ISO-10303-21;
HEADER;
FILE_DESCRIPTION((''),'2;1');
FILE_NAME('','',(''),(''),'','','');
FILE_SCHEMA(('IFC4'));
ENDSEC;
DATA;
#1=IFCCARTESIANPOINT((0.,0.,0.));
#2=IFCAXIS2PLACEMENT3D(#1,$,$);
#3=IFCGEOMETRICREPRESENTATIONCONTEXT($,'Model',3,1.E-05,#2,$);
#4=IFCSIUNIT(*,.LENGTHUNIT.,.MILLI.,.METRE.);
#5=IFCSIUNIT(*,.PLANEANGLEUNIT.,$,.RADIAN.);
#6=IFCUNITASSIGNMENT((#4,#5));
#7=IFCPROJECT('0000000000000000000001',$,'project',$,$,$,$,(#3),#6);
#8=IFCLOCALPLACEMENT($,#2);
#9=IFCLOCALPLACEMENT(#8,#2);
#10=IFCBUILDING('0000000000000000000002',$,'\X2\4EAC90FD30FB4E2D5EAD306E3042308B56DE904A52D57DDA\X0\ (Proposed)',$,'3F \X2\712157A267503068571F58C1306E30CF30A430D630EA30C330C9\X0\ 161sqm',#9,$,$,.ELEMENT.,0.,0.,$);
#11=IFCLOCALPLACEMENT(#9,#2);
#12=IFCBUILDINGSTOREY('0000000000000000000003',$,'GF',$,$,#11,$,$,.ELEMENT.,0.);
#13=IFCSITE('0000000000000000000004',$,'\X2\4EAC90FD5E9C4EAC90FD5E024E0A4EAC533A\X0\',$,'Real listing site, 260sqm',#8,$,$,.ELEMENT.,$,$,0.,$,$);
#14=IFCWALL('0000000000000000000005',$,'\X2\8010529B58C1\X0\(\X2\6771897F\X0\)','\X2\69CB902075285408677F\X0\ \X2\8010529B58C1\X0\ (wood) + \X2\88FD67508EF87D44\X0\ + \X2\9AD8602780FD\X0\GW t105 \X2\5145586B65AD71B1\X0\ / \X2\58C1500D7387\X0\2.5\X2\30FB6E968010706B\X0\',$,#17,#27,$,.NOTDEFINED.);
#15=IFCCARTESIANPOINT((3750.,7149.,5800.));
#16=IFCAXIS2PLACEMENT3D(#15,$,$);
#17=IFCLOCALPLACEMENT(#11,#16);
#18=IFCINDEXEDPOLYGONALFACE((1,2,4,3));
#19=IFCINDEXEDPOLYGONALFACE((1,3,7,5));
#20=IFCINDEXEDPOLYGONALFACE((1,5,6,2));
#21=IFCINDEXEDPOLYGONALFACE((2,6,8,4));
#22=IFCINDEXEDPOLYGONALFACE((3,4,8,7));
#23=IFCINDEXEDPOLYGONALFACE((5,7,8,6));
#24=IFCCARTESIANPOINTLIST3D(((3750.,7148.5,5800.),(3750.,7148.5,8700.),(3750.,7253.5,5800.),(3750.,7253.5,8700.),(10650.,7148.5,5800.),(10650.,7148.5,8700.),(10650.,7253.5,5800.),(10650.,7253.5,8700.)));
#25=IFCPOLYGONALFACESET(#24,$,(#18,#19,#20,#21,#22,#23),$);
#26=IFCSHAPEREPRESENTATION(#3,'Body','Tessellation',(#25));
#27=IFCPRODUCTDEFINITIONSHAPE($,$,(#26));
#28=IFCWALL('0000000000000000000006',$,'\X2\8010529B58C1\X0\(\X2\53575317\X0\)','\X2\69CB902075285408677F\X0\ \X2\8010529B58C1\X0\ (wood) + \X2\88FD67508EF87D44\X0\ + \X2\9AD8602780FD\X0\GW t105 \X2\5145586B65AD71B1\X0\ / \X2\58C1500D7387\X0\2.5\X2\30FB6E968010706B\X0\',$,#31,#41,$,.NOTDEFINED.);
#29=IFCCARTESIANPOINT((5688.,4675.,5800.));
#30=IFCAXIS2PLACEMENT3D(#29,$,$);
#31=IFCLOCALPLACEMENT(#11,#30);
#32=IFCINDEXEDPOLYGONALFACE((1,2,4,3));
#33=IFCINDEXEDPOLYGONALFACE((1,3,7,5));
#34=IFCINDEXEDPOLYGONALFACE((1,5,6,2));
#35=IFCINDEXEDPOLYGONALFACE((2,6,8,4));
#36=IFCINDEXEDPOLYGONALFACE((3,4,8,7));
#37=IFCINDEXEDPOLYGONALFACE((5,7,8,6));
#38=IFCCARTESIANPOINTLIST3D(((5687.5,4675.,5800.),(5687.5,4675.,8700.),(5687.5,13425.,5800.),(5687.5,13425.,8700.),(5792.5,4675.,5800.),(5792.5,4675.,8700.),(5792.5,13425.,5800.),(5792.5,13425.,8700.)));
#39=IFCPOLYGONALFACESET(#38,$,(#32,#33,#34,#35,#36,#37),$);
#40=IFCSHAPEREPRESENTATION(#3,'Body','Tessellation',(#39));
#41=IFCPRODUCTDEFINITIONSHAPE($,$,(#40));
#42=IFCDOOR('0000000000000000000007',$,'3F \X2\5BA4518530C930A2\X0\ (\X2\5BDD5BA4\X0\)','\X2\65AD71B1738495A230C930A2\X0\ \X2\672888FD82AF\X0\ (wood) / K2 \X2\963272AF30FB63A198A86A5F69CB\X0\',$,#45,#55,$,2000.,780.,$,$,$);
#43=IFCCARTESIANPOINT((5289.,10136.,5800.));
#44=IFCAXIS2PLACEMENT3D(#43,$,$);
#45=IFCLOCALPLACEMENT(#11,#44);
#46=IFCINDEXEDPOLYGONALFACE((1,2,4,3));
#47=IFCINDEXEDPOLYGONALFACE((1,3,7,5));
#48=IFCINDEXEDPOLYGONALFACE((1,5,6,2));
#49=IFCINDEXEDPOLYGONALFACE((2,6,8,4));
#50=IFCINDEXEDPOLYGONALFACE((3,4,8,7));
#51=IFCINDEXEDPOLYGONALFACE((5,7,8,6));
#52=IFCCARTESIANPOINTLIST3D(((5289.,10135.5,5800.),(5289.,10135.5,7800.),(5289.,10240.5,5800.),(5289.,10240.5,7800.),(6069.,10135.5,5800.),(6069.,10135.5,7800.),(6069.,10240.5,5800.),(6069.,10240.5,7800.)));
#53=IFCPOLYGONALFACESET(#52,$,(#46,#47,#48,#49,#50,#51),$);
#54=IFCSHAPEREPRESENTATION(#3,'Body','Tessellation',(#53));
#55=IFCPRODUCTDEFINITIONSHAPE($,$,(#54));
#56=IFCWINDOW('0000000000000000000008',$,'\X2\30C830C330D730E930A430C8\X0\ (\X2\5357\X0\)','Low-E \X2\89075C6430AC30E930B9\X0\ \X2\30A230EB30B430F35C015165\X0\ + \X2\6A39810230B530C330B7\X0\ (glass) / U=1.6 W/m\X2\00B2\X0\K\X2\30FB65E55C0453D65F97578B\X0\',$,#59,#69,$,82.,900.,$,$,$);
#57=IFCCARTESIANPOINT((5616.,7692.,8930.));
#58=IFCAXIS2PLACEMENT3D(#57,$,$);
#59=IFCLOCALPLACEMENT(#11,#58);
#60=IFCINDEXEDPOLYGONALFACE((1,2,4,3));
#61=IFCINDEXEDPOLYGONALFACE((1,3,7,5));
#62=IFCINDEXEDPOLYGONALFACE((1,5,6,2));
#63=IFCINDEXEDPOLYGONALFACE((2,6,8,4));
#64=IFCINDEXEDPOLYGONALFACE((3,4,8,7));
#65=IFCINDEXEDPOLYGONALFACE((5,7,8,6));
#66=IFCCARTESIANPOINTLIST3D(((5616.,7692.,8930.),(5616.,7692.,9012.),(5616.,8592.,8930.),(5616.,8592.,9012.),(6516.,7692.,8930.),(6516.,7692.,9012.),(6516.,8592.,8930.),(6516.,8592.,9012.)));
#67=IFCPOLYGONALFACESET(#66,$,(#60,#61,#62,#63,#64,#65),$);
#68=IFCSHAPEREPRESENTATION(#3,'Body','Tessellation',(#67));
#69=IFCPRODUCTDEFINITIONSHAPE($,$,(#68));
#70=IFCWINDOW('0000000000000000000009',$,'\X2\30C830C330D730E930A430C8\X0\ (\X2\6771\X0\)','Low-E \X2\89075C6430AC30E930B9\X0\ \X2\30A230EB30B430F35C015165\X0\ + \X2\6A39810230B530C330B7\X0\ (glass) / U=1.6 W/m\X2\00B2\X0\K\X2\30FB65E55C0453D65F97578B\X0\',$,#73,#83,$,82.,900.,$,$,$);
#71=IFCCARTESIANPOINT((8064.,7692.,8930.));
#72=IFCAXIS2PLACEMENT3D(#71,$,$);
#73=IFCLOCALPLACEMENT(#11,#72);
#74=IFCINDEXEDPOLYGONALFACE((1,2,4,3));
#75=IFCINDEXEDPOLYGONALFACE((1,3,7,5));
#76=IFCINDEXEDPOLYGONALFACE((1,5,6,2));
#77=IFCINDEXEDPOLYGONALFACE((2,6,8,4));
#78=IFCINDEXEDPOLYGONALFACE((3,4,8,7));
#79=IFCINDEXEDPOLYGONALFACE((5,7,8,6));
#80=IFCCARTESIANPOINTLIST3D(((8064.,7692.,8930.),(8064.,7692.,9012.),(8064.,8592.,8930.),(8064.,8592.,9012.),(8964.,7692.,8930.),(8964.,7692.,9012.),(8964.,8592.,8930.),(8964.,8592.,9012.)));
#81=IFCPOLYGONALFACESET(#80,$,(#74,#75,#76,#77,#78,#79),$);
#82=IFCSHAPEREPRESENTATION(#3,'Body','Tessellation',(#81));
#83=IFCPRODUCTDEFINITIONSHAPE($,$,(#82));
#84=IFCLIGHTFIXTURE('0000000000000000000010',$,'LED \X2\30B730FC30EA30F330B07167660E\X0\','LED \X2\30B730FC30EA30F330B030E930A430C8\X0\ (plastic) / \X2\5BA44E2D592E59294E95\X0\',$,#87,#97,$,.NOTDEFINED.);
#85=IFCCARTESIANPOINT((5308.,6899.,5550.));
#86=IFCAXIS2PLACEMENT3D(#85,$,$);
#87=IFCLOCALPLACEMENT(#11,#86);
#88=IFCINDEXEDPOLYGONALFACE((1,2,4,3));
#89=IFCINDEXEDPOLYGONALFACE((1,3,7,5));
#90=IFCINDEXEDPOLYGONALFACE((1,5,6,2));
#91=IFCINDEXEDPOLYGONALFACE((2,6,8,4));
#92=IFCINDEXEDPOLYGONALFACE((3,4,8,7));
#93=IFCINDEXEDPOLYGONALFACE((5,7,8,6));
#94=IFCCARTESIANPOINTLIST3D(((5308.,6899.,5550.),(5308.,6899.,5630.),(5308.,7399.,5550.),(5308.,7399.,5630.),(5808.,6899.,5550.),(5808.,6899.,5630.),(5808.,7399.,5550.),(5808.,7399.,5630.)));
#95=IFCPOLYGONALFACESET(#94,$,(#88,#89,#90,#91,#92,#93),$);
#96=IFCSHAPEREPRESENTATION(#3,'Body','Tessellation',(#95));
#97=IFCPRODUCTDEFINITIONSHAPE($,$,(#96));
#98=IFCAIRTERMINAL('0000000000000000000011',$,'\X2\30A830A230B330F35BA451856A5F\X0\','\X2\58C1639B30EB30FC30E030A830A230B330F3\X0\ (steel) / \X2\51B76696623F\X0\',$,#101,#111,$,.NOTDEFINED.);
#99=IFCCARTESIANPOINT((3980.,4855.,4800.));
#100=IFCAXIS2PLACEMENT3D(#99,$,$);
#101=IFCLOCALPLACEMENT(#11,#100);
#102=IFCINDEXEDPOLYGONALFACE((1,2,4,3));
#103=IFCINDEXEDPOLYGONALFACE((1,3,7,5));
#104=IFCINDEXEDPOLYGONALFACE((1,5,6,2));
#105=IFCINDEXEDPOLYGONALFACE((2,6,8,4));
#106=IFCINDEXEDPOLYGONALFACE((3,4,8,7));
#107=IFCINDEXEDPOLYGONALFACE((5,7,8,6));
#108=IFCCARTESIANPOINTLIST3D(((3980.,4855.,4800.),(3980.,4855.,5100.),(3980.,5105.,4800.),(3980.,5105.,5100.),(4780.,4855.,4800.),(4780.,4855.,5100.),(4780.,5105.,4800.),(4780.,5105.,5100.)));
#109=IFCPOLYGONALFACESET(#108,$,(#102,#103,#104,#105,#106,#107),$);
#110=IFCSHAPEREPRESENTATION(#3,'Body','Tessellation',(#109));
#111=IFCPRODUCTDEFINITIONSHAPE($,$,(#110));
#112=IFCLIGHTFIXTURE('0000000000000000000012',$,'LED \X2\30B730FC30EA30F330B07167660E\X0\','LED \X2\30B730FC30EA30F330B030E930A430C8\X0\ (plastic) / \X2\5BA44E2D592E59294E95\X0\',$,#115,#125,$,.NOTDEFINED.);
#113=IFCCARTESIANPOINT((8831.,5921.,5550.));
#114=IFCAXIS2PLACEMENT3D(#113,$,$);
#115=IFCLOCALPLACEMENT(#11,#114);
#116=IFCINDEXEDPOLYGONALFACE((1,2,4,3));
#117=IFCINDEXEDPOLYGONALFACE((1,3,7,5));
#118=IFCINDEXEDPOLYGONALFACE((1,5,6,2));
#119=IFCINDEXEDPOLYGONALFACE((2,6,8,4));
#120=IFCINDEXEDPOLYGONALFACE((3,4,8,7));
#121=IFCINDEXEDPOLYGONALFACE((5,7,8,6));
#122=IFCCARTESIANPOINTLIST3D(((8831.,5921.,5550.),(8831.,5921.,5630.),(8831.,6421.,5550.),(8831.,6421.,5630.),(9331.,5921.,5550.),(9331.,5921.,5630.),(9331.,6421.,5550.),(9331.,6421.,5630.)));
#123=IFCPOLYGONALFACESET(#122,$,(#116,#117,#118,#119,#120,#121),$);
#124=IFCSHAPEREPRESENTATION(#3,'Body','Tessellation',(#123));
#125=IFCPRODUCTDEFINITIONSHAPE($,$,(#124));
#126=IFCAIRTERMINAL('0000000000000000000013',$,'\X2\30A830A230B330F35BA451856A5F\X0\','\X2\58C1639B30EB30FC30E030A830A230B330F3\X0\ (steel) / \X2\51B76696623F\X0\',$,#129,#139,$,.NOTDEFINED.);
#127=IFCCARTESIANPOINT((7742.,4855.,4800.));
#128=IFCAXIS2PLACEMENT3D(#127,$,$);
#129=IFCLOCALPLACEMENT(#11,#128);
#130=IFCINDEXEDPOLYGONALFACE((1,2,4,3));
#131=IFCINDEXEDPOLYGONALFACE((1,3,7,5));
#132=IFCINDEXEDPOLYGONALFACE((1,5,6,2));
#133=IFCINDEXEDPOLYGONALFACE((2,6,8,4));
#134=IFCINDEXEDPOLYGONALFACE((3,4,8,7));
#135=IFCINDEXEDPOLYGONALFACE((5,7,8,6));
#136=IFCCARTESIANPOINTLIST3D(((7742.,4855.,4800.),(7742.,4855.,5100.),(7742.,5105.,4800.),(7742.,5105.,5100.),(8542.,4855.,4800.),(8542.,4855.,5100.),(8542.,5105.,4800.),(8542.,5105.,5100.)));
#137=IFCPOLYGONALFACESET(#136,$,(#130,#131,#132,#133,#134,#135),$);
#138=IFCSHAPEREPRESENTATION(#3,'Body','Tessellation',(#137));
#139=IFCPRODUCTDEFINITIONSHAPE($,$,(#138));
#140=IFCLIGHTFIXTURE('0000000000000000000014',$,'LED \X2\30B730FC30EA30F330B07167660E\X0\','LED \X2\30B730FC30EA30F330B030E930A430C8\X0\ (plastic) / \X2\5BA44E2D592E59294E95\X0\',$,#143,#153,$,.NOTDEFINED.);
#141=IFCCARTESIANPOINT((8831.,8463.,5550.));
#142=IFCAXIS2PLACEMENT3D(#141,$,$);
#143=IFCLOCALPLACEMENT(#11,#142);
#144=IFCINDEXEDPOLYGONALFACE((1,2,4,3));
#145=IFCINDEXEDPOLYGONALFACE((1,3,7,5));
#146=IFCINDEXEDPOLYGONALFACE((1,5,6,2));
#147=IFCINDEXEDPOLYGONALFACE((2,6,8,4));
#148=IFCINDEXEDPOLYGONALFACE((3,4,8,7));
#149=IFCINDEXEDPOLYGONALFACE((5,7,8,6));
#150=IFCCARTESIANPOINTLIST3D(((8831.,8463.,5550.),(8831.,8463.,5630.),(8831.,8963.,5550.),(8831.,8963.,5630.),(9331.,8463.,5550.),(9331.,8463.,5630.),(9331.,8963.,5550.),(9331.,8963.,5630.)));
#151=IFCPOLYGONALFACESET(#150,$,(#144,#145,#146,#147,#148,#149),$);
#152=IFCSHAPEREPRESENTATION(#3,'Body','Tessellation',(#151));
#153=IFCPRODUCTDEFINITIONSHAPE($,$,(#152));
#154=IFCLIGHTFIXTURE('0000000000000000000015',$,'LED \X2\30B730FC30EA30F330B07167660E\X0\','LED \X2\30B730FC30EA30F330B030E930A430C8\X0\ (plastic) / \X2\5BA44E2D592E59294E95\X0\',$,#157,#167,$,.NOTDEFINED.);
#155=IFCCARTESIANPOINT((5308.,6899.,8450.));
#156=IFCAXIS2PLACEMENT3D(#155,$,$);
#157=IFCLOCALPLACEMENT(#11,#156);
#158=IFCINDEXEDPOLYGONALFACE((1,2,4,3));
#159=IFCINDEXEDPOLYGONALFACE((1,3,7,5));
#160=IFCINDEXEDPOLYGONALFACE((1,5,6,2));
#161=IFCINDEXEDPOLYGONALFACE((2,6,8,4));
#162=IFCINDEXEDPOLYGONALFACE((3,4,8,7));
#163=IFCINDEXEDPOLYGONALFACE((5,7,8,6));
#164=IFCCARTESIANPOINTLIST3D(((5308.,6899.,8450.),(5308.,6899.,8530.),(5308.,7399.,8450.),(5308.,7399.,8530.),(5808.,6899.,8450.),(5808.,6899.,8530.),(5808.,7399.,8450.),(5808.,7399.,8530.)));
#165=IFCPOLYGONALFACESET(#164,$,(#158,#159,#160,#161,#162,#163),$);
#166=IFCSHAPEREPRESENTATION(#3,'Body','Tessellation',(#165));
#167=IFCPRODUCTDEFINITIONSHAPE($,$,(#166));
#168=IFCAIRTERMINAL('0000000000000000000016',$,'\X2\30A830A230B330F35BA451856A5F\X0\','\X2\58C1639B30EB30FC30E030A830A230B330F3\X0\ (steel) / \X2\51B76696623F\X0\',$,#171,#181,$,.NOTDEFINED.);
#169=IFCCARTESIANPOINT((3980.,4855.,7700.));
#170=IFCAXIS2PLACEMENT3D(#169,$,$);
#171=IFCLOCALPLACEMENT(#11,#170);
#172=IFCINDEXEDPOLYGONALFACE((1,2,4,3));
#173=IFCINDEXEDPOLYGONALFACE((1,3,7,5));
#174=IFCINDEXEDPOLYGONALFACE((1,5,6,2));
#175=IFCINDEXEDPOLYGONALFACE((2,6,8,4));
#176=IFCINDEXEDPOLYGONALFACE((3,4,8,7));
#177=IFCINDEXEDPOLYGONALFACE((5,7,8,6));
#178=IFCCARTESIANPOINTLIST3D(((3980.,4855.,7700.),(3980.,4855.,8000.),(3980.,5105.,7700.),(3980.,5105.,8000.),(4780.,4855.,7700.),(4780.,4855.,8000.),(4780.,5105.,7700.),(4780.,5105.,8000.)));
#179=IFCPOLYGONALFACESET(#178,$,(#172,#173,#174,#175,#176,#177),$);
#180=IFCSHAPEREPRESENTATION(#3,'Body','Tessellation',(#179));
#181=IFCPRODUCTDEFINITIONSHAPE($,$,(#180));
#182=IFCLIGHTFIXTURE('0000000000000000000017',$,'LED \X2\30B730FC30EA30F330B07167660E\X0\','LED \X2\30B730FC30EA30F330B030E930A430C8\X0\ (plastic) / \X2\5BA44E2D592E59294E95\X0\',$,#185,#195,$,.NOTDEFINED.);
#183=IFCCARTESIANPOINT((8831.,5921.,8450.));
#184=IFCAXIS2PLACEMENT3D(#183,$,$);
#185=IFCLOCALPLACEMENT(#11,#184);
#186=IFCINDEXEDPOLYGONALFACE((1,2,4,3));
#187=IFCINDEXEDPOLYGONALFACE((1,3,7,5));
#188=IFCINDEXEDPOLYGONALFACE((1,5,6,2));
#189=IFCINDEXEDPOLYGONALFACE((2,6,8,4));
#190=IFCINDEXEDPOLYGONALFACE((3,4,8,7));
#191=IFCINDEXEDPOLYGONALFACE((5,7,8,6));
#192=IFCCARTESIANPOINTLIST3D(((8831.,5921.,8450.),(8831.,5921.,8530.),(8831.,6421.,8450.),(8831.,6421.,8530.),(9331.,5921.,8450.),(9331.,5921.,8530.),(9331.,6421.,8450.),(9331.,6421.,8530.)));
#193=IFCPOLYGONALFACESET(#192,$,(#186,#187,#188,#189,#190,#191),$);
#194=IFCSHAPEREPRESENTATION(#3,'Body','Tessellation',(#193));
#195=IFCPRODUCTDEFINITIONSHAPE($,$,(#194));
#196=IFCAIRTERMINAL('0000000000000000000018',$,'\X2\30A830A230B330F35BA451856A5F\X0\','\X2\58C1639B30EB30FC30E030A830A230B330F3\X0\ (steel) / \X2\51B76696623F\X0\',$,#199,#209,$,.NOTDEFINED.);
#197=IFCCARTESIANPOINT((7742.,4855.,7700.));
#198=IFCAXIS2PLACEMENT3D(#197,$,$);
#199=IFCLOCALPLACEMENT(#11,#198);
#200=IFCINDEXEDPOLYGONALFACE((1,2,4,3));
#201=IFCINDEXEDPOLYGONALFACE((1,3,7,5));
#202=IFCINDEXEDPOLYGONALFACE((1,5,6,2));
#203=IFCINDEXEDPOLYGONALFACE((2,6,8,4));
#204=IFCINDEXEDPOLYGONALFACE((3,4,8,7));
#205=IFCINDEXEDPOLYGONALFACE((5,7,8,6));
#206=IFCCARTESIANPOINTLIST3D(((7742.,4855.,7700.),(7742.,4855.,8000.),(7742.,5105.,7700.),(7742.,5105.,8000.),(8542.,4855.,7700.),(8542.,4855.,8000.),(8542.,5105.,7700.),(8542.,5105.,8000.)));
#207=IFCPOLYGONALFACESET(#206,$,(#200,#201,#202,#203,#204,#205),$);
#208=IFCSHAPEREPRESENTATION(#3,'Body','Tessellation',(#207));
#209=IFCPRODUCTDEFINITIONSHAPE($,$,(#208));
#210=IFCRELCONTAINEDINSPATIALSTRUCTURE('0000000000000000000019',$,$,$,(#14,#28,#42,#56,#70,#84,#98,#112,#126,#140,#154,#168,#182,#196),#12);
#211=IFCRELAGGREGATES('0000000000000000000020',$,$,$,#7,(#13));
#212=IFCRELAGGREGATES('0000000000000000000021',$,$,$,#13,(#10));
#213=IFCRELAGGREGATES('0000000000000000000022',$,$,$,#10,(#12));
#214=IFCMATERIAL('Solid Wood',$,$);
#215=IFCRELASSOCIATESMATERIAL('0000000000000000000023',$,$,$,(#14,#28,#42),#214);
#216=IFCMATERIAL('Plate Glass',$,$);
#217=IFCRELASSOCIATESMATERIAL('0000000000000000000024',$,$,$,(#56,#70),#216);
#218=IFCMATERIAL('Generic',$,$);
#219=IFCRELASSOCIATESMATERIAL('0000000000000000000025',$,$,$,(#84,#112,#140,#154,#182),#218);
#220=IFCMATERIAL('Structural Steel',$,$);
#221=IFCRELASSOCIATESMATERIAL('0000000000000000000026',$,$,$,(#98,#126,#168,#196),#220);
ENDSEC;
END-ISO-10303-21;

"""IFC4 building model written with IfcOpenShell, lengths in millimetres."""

from ifc_helpers import new_model, si_unit, frame, frame_2d, origin, place, context, project, spatial, rectangle, extrude, material, element, fill, save


model = new_model("IFC4")

# Units and contexts
model_context = context("Model", 3, precision=1e-05, world=origin())
ifc_project = project(units=[si_unit("LENGTHUNIT", "METRE", prefix="MILLI"), si_unit("PLANEANGLEUNIT", "RADIAN")], contexts=[model_context])

# Site, building, storey
site_placement = place(None, origin())
site = spatial("IfcSite", under=ifc_project, at=site_placement, Name="京都府京都市上京区", ObjectType="Real listing site, 260sqm", CompositionType="ELEMENT", RefElevation=0.0)
building_placement = place(site_placement, origin())
building = spatial("IfcBuilding", under=site, at=building_placement, Name="京都・中庭のある回遊動線 (Proposed)", ObjectType="3F 無垢材と土壁のハイブリッド 161sqm", CompositionType="ELEMENT", ElevationOfRefHeight=0.0, ElevationOfTerrain=0.0)
storey_placement = place(building_placement, origin())
storey = spatial("IfcBuildingStorey", under=building, at=storey_placement, Name="GF", CompositionType="ELEMENT", Elevation=0.0)

# Shared definitions
ifc_material_1 = material(Name="Solid Wood")

# Wall
wall_1_placement = place(storey_placement, frame((3750.0, 7149.0, 5800.0)))
element("IfcWall", 1, at=wall_1_placement, inside=storey, material=ifc_material_1, Name="耐力壁(東西)", Description="構造用合板 耐力壁 (wood) + 製材軸組 + 高性能GW t105 充填断熱 / 壁倍率2.5・準耐火", PredefinedType="NOTDEFINED", context=model_context, shape_type="SweptSolid", body=[
    extrude(rectangle(XDim=6900.0, YDim=105.0, at=frame_2d((3450.0, 52.0))), frame((3750.0, 7149.0, 5800.0)), (0.0, 0.0, 1.0), 2900.0),
])

# Wall, opening, door
wall_2_placement = place(storey_placement, frame((5688.0, 4675.0, 5800.0)))
wall_2 = element("IfcWall", 2, at=wall_2_placement, inside=storey, material=ifc_material_1, Name="耐力壁(南北)", Description="構造用合板 耐力壁 (wood) + 製材軸組 + 高性能GW t105 充填断熱 / 壁倍率2.5・準耐火", PredefinedType="NOTDEFINED", context=model_context, shape_type="SweptSolid", body=[
    extrude(rectangle(XDim=105.0, YDim=8750.0, at=frame_2d((52.0, 4375.0))), frame((5688.0, 4675.0, 5800.0)), (0.0, 0.0, 1.0), 2900.0),
])
opening_placement = place(storey_placement, frame((5289.0, 10136.0, 5800.0)))
opening = element("IfcOpeningElement", 3, at=opening_placement, cuts=wall_2, PredefinedType="NOTDEFINED", context=model_context, shape_type="SweptSolid", body=[
    extrude(rectangle(XDim=780.0, YDim=105.0, at=frame_2d((390.0, 52.0))), frame((5289.0, 10136.0, 5800.0)), (0.0, 0.0, 1.0), 2000.0),
])
door_placement = place(storey_placement, frame((5289.0, 10136.0, 5800.0)))
door = element("IfcDoor", 4, at=door_placement, inside=storey, material=ifc_material_1, Name="3F 室内ドア (寝室)", Description="断熱玄関ドア 木製芯 (wood) / K2 防犯・採風機構", OverallHeight=2000.0, OverallWidth=780.0, context=model_context, shape_type="SweptSolid", body=[
    extrude(rectangle(XDim=780.0, YDim=105.0, at=frame_2d((390.0, 52.0))), frame((5289.0, 10136.0, 5800.0)), (0.0, 0.0, 1.0), 2000.0),
])
fill(opening, door)

# Windows
ifc_material_2 = material(Name="Plate Glass")
window_1_placement = place(storey_placement, frame((5616.0, 7692.0, 8930.0)))
element("IfcWindow", 5, at=window_1_placement, inside=storey, material=ifc_material_2, Name="トップライト (南)", Description="Low-E 複層ガラス アルゴン封入 + 樹脂サッシ (glass) / U=1.6 W/m²K・日射取得型", OverallHeight=82.0, OverallWidth=900.0, context=model_context, shape_type="SweptSolid", body=[
    extrude(rectangle(XDim=900.0, YDim=900.0, at=frame_2d((450.0, 450.0))), frame((5616.0, 7692.0, 8930.0)), (0.0, 0.0, 1.0), 82.0),
])
window_2_placement = place(storey_placement, frame((8064.0, 7692.0, 8930.0)))
element("IfcWindow", 6, at=window_2_placement, inside=storey, material=ifc_material_2, Name="トップライト (東)", Description="Low-E 複層ガラス アルゴン封入 + 樹脂サッシ (glass) / U=1.6 W/m²K・日射取得型", OverallHeight=82.0, OverallWidth=900.0, context=model_context, shape_type="SweptSolid", body=[
    extrude(rectangle(XDim=900.0, YDim=900.0, at=frame_2d((450.0, 450.0))), frame((8064.0, 7692.0, 8930.0)), (0.0, 0.0, 1.0), 82.0),
])

# Light fixture
ifc_material_3 = material(Name="Generic")
light_fixture_1_placement = place(storey_placement, frame((5308.0, 6899.0, 5550.0)))
element("IfcLightFixture", 7, at=light_fixture_1_placement, inside=storey, material=ifc_material_3, Name="LED シーリング照明", Description="LED シーリングライト (plastic) / 室中央天井", PredefinedType="NOTDEFINED", context=model_context, shape_type="SweptSolid", body=[
    extrude(rectangle(XDim=500.0, YDim=500.0, at=frame_2d((250.0, 250.0))), frame((5308.0, 6899.0, 5550.0)), (0.0, 0.0, 1.0), 80.0),
])

# Air terminal
ifc_material_4 = material(Name="Structural Steel")
air_terminal_1_placement = place(storey_placement, frame((3980.0, 4855.0, 4800.0)))
element("IfcAirTerminal", 8, at=air_terminal_1_placement, inside=storey, material=ifc_material_4, Name="エアコン室内機", Description="壁掛ルームエアコン (steel) / 冷暖房", PredefinedType="NOTDEFINED", context=model_context, shape_type="SweptSolid", body=[
    extrude(rectangle(XDim=800.0, YDim=250.0, at=frame_2d((400.0, 125.0))), frame((3980.0, 4855.0, 4800.0)), (0.0, 0.0, 1.0), 300.0),
])

# Light fixture
light_fixture_2_placement = place(storey_placement, frame((8831.0, 5921.0, 5550.0)))
element("IfcLightFixture", 9, at=light_fixture_2_placement, inside=storey, material=ifc_material_3, Name="LED シーリング照明", Description="LED シーリングライト (plastic) / 室中央天井", PredefinedType="NOTDEFINED", context=model_context, shape_type="SweptSolid", body=[
    extrude(rectangle(XDim=500.0, YDim=500.0, at=frame_2d((250.0, 250.0))), frame((8831.0, 5921.0, 5550.0)), (0.0, 0.0, 1.0), 80.0),
])

# Air terminal
air_terminal_2_placement = place(storey_placement, frame((7742.0, 4855.0, 4800.0)))
element("IfcAirTerminal", 10, at=air_terminal_2_placement, inside=storey, material=ifc_material_4, Name="エアコン室内機", Description="壁掛ルームエアコン (steel) / 冷暖房", PredefinedType="NOTDEFINED", context=model_context, shape_type="SweptSolid", body=[
    extrude(rectangle(XDim=800.0, YDim=250.0, at=frame_2d((400.0, 125.0))), frame((7742.0, 4855.0, 4800.0)), (0.0, 0.0, 1.0), 300.0),
])

# Light fixtures
light_fixture_3_placement = place(storey_placement, frame((8831.0, 8463.0, 5550.0)))
element("IfcLightFixture", 11, at=light_fixture_3_placement, inside=storey, material=ifc_material_3, Name="LED シーリング照明", Description="LED シーリングライト (plastic) / 室中央天井", PredefinedType="NOTDEFINED", context=model_context, shape_type="SweptSolid", body=[
    extrude(rectangle(XDim=500.0, YDim=500.0, at=frame_2d((250.0, 250.0))), frame((8831.0, 8463.0, 5550.0)), (0.0, 0.0, 1.0), 80.0),
])
light_fixture_4_placement = place(storey_placement, frame((5308.0, 6899.0, 8450.0)))
element("IfcLightFixture", 12, at=light_fixture_4_placement, inside=storey, material=ifc_material_3, Name="LED シーリング照明", Description="LED シーリングライト (plastic) / 室中央天井", PredefinedType="NOTDEFINED", context=model_context, shape_type="SweptSolid", body=[
    extrude(rectangle(XDim=500.0, YDim=500.0, at=frame_2d((250.0, 250.0))), frame((5308.0, 6899.0, 8450.0)), (0.0, 0.0, 1.0), 80.0),
])

# Air terminal
air_terminal_3_placement = place(storey_placement, frame((3980.0, 4855.0, 7700.0)))
element("IfcAirTerminal", 13, at=air_terminal_3_placement, inside=storey, material=ifc_material_4, Name="エアコン室内機", Description="壁掛ルームエアコン (steel) / 冷暖房", PredefinedType="NOTDEFINED", context=model_context, shape_type="SweptSolid", body=[
    extrude(rectangle(XDim=800.0, YDim=250.0, at=frame_2d((400.0, 125.0))), frame((3980.0, 4855.0, 7700.0)), (0.0, 0.0, 1.0), 300.0),
])

# Light fixture
light_fixture_5_placement = place(storey_placement, frame((8831.0, 5921.0, 8450.0)))
element("IfcLightFixture", 14, at=light_fixture_5_placement, inside=storey, material=ifc_material_3, Name="LED シーリング照明", Description="LED シーリングライト (plastic) / 室中央天井", PredefinedType="NOTDEFINED", context=model_context, shape_type="SweptSolid", body=[
    extrude(rectangle(XDim=500.0, YDim=500.0, at=frame_2d((250.0, 250.0))), frame((8831.0, 5921.0, 8450.0)), (0.0, 0.0, 1.0), 80.0),
])

# Air terminal
air_terminal_4_placement = place(storey_placement, frame((7742.0, 4855.0, 7700.0)))
element("IfcAirTerminal", 15, at=air_terminal_4_placement, inside=storey, material=ifc_material_4, Name="エアコン室内機", Description="壁掛ルームエアコン (steel) / 冷暖房", PredefinedType="NOTDEFINED", context=model_context, shape_type="SweptSolid", body=[
    extrude(rectangle(XDim=800.0, YDim=250.0, at=frame_2d((400.0, 125.0))), frame((7742.0, 4855.0, 7700.0)), (0.0, 0.0, 1.0), 300.0),
])

save(model, "model.ifc")
